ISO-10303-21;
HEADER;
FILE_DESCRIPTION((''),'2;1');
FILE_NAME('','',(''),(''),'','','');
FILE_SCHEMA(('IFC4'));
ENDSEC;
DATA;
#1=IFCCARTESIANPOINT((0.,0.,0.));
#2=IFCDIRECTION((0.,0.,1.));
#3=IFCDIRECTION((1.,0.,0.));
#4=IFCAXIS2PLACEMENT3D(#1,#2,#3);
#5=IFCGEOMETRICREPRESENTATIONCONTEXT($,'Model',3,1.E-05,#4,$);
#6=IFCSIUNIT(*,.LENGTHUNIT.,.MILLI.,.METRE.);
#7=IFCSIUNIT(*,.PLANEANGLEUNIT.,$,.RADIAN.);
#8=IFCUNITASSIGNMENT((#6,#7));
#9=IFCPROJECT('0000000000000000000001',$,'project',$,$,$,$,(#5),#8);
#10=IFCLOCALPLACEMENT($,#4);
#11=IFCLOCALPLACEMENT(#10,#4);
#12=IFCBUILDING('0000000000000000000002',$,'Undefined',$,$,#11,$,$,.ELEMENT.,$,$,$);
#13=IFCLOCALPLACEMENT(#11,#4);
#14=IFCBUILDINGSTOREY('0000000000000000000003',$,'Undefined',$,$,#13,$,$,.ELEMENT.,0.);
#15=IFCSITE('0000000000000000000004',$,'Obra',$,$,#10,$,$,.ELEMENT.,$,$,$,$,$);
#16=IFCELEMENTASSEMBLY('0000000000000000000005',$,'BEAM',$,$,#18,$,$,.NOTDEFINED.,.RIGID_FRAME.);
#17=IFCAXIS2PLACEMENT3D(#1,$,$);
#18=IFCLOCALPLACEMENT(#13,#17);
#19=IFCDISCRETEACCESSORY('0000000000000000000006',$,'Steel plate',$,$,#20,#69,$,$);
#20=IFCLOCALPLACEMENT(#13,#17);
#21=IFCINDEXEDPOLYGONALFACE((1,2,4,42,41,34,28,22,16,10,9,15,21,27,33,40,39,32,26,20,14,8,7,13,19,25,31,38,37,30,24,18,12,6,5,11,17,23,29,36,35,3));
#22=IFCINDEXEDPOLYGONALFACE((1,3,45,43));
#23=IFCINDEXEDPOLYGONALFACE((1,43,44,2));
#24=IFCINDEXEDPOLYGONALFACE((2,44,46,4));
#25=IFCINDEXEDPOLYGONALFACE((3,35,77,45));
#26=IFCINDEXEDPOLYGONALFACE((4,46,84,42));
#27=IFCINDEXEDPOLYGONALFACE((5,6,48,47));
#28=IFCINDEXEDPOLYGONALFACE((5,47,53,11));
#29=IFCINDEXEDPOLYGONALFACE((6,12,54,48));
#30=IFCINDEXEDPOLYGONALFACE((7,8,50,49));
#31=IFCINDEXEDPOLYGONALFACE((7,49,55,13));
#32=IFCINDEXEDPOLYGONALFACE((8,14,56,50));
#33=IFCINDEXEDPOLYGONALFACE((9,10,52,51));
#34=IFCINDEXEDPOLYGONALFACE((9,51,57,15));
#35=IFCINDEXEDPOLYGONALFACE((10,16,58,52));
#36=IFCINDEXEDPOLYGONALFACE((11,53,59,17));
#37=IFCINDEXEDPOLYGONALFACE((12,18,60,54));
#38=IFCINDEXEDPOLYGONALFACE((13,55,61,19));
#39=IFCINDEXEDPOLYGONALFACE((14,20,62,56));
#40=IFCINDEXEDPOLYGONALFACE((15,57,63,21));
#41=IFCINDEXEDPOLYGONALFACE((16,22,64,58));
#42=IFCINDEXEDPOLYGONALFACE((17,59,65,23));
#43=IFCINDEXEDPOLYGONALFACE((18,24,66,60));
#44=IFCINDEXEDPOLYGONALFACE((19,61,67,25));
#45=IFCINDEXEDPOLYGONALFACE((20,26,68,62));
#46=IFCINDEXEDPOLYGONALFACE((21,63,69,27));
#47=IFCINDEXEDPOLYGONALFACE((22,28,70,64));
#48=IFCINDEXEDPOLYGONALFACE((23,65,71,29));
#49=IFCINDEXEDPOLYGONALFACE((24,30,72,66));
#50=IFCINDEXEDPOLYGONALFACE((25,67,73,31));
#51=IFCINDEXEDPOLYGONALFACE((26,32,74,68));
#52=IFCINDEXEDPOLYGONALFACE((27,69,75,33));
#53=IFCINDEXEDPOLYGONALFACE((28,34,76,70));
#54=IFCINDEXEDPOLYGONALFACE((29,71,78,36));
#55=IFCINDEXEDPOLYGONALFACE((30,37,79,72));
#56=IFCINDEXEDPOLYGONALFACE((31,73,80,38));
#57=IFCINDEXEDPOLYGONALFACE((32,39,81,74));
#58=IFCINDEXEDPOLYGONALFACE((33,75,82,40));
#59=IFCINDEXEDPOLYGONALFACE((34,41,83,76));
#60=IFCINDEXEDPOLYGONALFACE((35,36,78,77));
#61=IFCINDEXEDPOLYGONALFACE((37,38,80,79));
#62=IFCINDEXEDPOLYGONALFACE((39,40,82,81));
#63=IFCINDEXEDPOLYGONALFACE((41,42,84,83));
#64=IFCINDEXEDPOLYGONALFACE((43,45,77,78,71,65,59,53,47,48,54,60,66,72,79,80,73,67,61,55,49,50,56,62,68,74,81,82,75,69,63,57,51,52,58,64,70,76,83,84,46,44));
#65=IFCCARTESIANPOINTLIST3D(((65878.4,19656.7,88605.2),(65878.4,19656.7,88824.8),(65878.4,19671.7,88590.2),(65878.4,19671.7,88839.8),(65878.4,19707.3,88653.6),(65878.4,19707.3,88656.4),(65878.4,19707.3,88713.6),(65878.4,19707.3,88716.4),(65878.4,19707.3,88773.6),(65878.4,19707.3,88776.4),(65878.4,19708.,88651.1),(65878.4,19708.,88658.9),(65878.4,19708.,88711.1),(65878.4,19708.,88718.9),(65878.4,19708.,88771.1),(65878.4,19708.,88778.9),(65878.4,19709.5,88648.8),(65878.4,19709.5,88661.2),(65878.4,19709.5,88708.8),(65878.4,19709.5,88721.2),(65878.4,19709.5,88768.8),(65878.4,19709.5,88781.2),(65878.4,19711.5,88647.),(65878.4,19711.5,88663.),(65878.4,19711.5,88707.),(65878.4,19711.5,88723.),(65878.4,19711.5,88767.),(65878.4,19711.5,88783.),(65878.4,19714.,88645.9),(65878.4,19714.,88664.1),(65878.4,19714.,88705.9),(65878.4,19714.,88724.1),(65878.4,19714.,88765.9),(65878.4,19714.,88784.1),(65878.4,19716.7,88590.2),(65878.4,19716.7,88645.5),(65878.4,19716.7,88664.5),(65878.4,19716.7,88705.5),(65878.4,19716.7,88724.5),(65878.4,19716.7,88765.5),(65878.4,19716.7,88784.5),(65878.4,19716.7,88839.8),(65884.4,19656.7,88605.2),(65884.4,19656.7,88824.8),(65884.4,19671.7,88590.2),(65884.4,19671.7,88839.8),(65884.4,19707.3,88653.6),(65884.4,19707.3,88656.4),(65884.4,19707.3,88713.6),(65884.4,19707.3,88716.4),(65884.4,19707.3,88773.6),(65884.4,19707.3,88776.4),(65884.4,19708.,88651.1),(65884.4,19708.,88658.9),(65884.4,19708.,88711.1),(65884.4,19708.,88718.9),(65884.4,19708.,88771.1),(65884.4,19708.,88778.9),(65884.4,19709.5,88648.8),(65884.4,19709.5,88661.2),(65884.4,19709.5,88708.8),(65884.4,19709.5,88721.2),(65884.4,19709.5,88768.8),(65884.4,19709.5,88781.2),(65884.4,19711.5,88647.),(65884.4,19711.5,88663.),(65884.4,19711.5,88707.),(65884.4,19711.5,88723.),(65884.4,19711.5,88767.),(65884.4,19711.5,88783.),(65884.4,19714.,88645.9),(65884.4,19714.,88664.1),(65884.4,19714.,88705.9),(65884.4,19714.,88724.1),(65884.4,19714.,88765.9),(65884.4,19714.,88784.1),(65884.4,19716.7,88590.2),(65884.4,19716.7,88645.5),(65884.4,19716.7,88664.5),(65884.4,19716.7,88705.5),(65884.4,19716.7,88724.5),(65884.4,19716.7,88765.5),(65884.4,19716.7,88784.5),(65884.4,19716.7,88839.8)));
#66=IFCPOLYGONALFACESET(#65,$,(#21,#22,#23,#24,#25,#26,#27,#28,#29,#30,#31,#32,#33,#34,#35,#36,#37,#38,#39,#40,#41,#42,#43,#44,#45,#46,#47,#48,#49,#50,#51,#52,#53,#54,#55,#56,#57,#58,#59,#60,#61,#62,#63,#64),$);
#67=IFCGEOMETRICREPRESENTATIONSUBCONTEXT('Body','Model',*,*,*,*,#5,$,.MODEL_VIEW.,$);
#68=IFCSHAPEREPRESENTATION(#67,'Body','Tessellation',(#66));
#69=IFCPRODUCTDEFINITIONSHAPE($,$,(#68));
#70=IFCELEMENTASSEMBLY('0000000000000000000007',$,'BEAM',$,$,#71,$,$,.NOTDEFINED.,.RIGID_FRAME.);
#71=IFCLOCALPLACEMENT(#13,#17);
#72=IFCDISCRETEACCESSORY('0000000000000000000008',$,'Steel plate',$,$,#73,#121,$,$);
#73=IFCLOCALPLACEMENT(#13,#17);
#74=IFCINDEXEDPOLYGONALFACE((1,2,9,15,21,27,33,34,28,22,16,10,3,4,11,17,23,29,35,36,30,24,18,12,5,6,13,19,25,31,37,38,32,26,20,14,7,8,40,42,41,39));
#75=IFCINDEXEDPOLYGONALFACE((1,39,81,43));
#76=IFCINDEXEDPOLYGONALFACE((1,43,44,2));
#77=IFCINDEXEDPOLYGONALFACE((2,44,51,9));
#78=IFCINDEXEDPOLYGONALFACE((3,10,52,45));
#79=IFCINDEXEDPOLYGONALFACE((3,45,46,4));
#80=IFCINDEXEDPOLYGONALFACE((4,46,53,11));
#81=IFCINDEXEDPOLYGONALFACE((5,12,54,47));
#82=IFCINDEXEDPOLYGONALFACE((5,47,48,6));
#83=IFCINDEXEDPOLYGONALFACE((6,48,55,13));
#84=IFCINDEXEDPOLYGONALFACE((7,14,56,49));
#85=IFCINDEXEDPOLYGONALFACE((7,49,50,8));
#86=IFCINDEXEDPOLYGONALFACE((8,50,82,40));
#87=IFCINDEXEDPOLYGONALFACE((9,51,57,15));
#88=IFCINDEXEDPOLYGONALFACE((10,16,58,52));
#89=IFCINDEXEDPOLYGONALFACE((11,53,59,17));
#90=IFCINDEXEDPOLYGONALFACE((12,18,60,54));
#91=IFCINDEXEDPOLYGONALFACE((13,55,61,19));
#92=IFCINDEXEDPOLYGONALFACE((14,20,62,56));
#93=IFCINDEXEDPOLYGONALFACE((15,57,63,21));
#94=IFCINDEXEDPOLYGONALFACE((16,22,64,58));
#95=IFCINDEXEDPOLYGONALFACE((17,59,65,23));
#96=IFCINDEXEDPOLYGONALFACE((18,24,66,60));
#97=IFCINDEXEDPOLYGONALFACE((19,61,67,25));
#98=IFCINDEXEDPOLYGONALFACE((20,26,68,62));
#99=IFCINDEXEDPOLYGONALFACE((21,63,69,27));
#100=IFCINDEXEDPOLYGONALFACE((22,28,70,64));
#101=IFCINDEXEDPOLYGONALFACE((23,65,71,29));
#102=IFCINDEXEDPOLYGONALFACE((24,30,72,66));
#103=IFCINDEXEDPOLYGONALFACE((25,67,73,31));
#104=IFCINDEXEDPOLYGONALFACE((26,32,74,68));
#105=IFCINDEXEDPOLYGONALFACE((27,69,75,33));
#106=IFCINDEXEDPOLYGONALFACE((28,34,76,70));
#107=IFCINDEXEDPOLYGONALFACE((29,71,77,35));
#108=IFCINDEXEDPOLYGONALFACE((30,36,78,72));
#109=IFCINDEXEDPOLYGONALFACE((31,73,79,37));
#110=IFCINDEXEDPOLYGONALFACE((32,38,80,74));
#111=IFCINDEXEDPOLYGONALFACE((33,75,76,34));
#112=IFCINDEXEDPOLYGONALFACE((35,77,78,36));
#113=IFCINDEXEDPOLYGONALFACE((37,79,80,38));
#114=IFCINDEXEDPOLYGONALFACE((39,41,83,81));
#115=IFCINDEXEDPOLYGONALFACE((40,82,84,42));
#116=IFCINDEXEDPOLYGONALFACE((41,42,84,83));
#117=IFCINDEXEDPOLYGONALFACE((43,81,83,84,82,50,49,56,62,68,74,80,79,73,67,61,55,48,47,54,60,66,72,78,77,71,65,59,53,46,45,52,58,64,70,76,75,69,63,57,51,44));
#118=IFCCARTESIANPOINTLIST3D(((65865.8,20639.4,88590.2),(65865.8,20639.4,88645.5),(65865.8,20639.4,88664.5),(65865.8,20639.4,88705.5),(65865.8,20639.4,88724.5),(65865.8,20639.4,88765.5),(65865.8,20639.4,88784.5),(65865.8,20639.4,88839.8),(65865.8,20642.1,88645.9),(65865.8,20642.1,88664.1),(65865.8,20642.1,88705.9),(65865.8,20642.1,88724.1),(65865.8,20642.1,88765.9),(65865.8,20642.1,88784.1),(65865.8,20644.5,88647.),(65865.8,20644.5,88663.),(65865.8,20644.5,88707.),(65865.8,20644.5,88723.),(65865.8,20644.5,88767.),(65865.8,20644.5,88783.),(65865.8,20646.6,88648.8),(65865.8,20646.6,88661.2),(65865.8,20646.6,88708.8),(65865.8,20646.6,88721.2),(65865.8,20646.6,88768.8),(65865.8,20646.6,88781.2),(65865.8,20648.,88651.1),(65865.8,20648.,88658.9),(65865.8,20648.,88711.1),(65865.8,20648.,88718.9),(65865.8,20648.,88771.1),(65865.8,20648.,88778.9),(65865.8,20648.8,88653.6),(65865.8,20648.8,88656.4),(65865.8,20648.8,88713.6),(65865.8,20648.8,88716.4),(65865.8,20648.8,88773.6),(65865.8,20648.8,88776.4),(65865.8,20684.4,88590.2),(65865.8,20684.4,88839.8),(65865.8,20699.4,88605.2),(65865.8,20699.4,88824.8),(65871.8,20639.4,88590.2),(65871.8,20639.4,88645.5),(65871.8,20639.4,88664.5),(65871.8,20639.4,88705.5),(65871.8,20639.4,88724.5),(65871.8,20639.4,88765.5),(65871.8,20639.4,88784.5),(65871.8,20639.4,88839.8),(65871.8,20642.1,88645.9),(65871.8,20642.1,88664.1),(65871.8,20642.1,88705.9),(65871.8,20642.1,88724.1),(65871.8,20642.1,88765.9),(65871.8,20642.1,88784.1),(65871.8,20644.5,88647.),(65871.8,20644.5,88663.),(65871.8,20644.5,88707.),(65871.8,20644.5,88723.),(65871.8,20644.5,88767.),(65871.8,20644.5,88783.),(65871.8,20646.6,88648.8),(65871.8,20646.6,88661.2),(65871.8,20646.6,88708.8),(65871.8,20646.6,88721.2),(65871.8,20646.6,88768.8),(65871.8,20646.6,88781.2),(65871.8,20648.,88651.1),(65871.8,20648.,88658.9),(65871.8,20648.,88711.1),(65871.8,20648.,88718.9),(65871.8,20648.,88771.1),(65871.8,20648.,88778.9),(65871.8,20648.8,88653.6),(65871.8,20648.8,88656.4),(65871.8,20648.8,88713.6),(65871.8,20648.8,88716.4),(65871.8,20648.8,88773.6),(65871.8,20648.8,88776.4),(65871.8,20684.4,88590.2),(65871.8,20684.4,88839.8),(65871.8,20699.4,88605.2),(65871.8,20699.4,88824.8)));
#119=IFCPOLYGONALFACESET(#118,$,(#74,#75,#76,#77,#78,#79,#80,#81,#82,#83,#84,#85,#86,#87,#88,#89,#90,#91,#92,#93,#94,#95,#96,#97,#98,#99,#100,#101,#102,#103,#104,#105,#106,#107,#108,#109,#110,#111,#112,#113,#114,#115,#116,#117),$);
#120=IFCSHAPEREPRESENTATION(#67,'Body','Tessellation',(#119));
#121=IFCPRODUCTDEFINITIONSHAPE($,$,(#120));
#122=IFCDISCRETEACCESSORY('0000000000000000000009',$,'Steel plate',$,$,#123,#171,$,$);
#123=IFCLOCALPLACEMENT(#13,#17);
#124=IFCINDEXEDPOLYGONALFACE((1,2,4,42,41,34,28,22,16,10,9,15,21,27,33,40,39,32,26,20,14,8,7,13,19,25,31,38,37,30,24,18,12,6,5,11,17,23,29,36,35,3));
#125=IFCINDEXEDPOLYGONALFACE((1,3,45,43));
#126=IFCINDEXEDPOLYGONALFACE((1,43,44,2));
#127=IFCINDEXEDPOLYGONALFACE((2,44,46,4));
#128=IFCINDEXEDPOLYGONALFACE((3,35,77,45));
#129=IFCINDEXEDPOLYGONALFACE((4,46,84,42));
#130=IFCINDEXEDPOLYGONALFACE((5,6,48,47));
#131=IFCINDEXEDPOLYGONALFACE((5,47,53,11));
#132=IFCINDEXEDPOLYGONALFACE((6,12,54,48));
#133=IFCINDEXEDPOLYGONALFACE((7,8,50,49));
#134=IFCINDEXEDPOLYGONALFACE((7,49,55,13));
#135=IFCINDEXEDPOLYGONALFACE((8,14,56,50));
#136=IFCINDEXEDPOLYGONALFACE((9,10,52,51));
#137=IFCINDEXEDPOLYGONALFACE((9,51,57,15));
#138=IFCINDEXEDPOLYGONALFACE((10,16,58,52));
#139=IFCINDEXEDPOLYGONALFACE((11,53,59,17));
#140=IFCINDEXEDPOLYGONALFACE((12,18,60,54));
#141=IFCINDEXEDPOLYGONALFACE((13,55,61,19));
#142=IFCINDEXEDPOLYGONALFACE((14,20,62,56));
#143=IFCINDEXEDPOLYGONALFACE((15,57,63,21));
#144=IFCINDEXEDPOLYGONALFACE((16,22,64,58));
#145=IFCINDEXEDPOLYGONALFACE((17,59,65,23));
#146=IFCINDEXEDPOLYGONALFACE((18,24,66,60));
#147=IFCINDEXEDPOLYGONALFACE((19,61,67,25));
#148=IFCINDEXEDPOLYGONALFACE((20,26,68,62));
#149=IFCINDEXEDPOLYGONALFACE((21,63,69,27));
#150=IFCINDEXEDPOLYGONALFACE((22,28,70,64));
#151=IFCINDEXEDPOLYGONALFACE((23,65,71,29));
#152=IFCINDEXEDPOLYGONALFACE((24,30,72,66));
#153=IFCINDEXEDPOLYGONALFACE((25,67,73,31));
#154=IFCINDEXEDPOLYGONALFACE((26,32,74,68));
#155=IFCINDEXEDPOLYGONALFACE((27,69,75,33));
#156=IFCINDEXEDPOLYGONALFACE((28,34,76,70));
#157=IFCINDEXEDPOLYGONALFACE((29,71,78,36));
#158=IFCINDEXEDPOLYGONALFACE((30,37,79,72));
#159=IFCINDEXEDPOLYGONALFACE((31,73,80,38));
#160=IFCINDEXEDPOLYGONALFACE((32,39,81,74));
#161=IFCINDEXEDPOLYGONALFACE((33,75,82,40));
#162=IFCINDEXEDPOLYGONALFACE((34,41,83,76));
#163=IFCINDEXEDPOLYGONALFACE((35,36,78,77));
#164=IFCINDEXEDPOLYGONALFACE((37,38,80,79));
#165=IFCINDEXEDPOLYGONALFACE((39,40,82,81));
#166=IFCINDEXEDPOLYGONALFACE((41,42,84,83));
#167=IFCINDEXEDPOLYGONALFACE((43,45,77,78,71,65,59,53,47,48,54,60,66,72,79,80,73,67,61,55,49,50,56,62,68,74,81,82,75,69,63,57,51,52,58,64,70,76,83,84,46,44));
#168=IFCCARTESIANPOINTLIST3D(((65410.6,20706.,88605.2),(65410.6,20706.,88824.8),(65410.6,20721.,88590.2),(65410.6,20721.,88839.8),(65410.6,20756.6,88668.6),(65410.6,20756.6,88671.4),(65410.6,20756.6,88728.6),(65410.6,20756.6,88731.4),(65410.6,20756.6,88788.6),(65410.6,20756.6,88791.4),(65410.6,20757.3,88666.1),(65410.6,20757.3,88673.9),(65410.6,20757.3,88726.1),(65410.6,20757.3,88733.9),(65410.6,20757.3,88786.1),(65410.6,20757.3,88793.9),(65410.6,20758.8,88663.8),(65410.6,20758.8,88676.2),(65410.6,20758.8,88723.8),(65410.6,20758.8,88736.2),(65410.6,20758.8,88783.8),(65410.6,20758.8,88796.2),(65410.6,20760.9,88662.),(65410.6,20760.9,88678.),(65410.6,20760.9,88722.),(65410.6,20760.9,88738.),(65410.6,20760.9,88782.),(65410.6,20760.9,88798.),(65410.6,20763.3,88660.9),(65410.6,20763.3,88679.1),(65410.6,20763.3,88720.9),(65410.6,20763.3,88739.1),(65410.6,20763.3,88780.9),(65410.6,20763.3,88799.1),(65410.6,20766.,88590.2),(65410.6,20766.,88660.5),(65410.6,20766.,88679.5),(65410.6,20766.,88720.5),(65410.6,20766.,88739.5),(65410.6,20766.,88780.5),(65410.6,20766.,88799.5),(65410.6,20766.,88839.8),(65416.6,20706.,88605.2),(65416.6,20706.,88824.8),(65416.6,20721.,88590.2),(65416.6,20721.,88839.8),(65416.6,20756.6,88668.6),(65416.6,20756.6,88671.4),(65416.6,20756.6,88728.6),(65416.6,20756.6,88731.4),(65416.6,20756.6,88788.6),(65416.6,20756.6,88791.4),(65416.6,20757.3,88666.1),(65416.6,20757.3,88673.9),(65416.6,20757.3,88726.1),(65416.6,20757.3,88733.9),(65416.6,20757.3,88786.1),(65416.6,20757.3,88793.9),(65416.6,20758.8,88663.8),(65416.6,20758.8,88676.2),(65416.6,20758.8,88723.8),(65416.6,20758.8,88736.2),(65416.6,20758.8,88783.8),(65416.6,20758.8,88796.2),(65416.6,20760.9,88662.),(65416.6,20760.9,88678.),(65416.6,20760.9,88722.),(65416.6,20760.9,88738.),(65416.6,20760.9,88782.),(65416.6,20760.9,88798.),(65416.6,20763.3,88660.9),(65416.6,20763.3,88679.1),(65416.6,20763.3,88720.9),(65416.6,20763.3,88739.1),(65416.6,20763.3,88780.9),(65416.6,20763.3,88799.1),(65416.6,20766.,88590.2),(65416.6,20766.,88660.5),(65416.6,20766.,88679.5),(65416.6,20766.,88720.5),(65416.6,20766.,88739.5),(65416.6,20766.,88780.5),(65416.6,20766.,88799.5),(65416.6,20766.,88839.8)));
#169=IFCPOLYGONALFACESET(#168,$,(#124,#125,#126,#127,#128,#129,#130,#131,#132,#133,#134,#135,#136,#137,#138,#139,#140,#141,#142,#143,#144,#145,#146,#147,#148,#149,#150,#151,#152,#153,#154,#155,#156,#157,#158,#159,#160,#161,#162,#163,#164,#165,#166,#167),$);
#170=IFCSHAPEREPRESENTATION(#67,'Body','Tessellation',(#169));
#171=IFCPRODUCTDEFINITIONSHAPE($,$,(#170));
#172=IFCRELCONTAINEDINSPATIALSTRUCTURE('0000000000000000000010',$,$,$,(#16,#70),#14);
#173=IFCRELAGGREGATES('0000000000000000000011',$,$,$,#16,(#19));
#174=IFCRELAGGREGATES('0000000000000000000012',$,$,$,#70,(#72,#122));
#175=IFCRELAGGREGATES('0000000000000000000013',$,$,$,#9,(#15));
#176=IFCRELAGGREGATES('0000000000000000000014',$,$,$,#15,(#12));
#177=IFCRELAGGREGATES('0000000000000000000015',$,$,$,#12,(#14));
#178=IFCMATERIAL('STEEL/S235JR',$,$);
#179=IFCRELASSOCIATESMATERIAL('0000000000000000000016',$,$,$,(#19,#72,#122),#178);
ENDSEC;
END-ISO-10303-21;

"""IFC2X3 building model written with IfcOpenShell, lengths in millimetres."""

from ifc_helpers import new_model, si_unit, frame, origin_with_axes, origin_2d_with_axis, place, context, subcontext, project, spatial, polyline, circle, outline, extrude, source, transform, mapped, material, element, aggregate, save


model = new_model("IFC2X3")

# Units and contexts
model_context = context("Model", 3, precision=1e-05, world=origin_with_axes())
body_context = subcontext(model_context, "Body", "Model", "MODEL_VIEW")
ifc_project = project(units=[si_unit("LENGTHUNIT", "METRE", prefix="MILLI"), si_unit("PLANEANGLEUNIT", "RADIAN")], contexts=[model_context])

# Site, building, storey
site_placement = place(None, origin_with_axes())
site = spatial("IfcSite", under=ifc_project, at=site_placement, Name="Obra", CompositionType="ELEMENT")
building_placement = place(site_placement, origin_with_axes())
building = spatial("IfcBuilding", under=site, at=building_placement, Name="Undefined", CompositionType="ELEMENT")
storey_placement = place(building_placement, origin_with_axes())
storey = spatial("IfcBuildingStorey", under=building, at=storey_placement, Name="Undefined", CompositionType="ELEMENT", Elevation=0.0)

# Shared definitions
ifc_material = material(Name="STEEL/S235JR")

# Element assemblies, discrete accessories, openings
shared_shape_1 = source(origin_with_axes(), body_context, "Body", "SweptSolid", [
    extrude(circle(Radius=9.5, at=origin_2d_with_axis()), frame((0.0, -9.4, 0.0), z_axis=(0.0, 1.0, 0.0), x_axis=(1.0, 0.0, 0.0)), (0.0, 0.0, 1.0), 6.2),
])
assembly_1_placement = place(storey_placement, origin_with_axes())
assembly_1 = element("IfcElementAssembly", 1, at=assembly_1_placement, inside=storey, Name="BEAM", AssemblyPlace="NOTDEFINED", PredefinedType="RIGID_FRAME")
discrete_accessory_1_placement = place(assembly_1_placement, frame((65881.4, 19716.7, 88590.2), z_axis=(-1.0, -0.000002, 0.0), x_axis=(0.000002, -1.0, 0.0)))
discrete_accessory_1 = element("IfcDiscreteAccessory", 2, at=discrete_accessory_1_placement, material=ifc_material, Name="Steel plate", context=body_context, shape_type="SweptSolid", body=[
    extrude(outline(polyline([(0.0, 0.0), (45.0, 0.0), (60.0, 15.0), (60.0, 234.6), (45.0, 249.6), (0.0, 249.6), (0.0, 0.0)])), frame((0.0, 0.0, -3.0), z_axis=(0.0, 0.0, 1.0), x_axis=(1.0, 0.0, 0.0)), (0.0, 0.0, 1.0), 6.0),
])
opening_1_placement = place(assembly_1_placement, frame((65875.1, 19666.7, 88850.0), z_axis=(-0.000002, 1.0, 0.0), x_axis=(0.0, 0.0, -1.0)))
element("IfcOpeningElement", 3, at=opening_1_placement, cuts=discrete_accessory_1, ObjectType="Opening", context=body_context, shape_type="MappedRepresentation", body=[
    mapped(shared_shape_1, transform((75.0, 0.0, 50.0))),
    mapped(shared_shape_1, transform((135.0, 0.0, 50.0))),
    mapped(shared_shape_1, transform((195.0, 0.0, 50.0))),
])
aggregate(assembly_1, [discrete_accessory_1])
assembly_2_placement = place(storey_placement, origin_with_axes())
assembly_2 = element("IfcElementAssembly", 4, at=assembly_2_placement, inside=storey, Name="BEAM", AssemblyPlace="NOTDEFINED", PredefinedType="RIGID_FRAME")
discrete_accessory_2_placement = place(assembly_2_placement, frame((65868.8, 20639.4, 88590.2), z_axis=(1.0, 0.000001, 0.0), x_axis=(-0.000002, 1.0, 0.0)))
discrete_accessory_2 = element("IfcDiscreteAccessory", 5, at=discrete_accessory_2_placement, material=ifc_material, Name="Steel plate", context=body_context, shape_type="SweptSolid", body=[
    extrude(outline(polyline([(0.0, 0.0), (45.0, 0.0), (60.0, 15.0), (60.0, 234.6), (45.0, 249.6), (0.0, 249.6), (0.0, 0.0)])), frame((0.0, 0.0, -3.0), z_axis=(0.0, 0.0, 1.0), x_axis=(1.0, 0.0, 0.0)), (0.0, 0.0, 1.0), 6.0),
])
opening_2_placement = place(assembly_2_placement, frame((65875.1, 20689.4, 88850.0), z_axis=(0.000002, -1.0, 0.0), x_axis=(0.0, 0.0, -1.0)))
element("IfcOpeningElement", 6, at=opening_2_placement, cuts=discrete_accessory_2, ObjectType="Opening", context=body_context, shape_type="MappedRepresentation", body=[
    mapped(shared_shape_1, transform((75.0, 0.0, 50.0))),
    mapped(shared_shape_1, transform((135.0, 0.0, 50.0))),
    mapped(shared_shape_1, transform((195.0, 0.0, 50.0))),
])
discrete_accessory_3_placement = place(assembly_2_placement, frame((65413.6, 20766.0, 88590.2), z_axis=(-1.0, -0.000002, 0.0), x_axis=(0.000002, -1.0, 0.0)))
discrete_accessory_3 = element("IfcDiscreteAccessory", 7, at=discrete_accessory_3_placement, material=ifc_material, Name="Steel plate", context=body_context, shape_type="SweptSolid", body=[
    extrude(outline(polyline([(0.0, 0.0), (45.0, 0.0), (60.0, 15.0), (60.0, 234.6), (45.0, 249.6), (0.0, 249.6), (0.0, 0.0)])), frame((0.0, 0.0, -3.0), z_axis=(0.0, 0.0, 1.0), x_axis=(1.0, 0.0, 0.0)), (0.0, 0.0, 1.0), 6.0),
])
shared_shape_2 = source(origin_with_axes(), body_context, "Body", "SweptSolid", [
    extrude(circle(Radius=9.5, at=origin_2d_with_axis()), frame((0.0, -9.2, 0.0), z_axis=(0.0, 1.0, 0.0), x_axis=(1.0, 0.0, 0.0)), (0.0, 0.0, 1.0), 6.2),
])
opening_3_placement = place(assembly_2_placement, frame((65407.5, 20716.0, 88850.0), z_axis=(-0.000002, 1.0, 0.0), x_axis=(0.0, 0.0, -1.0)))
element("IfcOpeningElement", 8, at=opening_3_placement, cuts=discrete_accessory_3, ObjectType="Opening", context=body_context, shape_type="MappedRepresentation", body=[
    mapped(shared_shape_2, transform((60.0, 0.0, 50.0))),
    mapped(shared_shape_2, transform((120.0, 0.0, 50.0))),
    mapped(shared_shape_2, transform((180.0, 0.0, 50.0))),
])
aggregate(assembly_2, [discrete_accessory_2, discrete_accessory_3])

save(model, "model.ifc")
